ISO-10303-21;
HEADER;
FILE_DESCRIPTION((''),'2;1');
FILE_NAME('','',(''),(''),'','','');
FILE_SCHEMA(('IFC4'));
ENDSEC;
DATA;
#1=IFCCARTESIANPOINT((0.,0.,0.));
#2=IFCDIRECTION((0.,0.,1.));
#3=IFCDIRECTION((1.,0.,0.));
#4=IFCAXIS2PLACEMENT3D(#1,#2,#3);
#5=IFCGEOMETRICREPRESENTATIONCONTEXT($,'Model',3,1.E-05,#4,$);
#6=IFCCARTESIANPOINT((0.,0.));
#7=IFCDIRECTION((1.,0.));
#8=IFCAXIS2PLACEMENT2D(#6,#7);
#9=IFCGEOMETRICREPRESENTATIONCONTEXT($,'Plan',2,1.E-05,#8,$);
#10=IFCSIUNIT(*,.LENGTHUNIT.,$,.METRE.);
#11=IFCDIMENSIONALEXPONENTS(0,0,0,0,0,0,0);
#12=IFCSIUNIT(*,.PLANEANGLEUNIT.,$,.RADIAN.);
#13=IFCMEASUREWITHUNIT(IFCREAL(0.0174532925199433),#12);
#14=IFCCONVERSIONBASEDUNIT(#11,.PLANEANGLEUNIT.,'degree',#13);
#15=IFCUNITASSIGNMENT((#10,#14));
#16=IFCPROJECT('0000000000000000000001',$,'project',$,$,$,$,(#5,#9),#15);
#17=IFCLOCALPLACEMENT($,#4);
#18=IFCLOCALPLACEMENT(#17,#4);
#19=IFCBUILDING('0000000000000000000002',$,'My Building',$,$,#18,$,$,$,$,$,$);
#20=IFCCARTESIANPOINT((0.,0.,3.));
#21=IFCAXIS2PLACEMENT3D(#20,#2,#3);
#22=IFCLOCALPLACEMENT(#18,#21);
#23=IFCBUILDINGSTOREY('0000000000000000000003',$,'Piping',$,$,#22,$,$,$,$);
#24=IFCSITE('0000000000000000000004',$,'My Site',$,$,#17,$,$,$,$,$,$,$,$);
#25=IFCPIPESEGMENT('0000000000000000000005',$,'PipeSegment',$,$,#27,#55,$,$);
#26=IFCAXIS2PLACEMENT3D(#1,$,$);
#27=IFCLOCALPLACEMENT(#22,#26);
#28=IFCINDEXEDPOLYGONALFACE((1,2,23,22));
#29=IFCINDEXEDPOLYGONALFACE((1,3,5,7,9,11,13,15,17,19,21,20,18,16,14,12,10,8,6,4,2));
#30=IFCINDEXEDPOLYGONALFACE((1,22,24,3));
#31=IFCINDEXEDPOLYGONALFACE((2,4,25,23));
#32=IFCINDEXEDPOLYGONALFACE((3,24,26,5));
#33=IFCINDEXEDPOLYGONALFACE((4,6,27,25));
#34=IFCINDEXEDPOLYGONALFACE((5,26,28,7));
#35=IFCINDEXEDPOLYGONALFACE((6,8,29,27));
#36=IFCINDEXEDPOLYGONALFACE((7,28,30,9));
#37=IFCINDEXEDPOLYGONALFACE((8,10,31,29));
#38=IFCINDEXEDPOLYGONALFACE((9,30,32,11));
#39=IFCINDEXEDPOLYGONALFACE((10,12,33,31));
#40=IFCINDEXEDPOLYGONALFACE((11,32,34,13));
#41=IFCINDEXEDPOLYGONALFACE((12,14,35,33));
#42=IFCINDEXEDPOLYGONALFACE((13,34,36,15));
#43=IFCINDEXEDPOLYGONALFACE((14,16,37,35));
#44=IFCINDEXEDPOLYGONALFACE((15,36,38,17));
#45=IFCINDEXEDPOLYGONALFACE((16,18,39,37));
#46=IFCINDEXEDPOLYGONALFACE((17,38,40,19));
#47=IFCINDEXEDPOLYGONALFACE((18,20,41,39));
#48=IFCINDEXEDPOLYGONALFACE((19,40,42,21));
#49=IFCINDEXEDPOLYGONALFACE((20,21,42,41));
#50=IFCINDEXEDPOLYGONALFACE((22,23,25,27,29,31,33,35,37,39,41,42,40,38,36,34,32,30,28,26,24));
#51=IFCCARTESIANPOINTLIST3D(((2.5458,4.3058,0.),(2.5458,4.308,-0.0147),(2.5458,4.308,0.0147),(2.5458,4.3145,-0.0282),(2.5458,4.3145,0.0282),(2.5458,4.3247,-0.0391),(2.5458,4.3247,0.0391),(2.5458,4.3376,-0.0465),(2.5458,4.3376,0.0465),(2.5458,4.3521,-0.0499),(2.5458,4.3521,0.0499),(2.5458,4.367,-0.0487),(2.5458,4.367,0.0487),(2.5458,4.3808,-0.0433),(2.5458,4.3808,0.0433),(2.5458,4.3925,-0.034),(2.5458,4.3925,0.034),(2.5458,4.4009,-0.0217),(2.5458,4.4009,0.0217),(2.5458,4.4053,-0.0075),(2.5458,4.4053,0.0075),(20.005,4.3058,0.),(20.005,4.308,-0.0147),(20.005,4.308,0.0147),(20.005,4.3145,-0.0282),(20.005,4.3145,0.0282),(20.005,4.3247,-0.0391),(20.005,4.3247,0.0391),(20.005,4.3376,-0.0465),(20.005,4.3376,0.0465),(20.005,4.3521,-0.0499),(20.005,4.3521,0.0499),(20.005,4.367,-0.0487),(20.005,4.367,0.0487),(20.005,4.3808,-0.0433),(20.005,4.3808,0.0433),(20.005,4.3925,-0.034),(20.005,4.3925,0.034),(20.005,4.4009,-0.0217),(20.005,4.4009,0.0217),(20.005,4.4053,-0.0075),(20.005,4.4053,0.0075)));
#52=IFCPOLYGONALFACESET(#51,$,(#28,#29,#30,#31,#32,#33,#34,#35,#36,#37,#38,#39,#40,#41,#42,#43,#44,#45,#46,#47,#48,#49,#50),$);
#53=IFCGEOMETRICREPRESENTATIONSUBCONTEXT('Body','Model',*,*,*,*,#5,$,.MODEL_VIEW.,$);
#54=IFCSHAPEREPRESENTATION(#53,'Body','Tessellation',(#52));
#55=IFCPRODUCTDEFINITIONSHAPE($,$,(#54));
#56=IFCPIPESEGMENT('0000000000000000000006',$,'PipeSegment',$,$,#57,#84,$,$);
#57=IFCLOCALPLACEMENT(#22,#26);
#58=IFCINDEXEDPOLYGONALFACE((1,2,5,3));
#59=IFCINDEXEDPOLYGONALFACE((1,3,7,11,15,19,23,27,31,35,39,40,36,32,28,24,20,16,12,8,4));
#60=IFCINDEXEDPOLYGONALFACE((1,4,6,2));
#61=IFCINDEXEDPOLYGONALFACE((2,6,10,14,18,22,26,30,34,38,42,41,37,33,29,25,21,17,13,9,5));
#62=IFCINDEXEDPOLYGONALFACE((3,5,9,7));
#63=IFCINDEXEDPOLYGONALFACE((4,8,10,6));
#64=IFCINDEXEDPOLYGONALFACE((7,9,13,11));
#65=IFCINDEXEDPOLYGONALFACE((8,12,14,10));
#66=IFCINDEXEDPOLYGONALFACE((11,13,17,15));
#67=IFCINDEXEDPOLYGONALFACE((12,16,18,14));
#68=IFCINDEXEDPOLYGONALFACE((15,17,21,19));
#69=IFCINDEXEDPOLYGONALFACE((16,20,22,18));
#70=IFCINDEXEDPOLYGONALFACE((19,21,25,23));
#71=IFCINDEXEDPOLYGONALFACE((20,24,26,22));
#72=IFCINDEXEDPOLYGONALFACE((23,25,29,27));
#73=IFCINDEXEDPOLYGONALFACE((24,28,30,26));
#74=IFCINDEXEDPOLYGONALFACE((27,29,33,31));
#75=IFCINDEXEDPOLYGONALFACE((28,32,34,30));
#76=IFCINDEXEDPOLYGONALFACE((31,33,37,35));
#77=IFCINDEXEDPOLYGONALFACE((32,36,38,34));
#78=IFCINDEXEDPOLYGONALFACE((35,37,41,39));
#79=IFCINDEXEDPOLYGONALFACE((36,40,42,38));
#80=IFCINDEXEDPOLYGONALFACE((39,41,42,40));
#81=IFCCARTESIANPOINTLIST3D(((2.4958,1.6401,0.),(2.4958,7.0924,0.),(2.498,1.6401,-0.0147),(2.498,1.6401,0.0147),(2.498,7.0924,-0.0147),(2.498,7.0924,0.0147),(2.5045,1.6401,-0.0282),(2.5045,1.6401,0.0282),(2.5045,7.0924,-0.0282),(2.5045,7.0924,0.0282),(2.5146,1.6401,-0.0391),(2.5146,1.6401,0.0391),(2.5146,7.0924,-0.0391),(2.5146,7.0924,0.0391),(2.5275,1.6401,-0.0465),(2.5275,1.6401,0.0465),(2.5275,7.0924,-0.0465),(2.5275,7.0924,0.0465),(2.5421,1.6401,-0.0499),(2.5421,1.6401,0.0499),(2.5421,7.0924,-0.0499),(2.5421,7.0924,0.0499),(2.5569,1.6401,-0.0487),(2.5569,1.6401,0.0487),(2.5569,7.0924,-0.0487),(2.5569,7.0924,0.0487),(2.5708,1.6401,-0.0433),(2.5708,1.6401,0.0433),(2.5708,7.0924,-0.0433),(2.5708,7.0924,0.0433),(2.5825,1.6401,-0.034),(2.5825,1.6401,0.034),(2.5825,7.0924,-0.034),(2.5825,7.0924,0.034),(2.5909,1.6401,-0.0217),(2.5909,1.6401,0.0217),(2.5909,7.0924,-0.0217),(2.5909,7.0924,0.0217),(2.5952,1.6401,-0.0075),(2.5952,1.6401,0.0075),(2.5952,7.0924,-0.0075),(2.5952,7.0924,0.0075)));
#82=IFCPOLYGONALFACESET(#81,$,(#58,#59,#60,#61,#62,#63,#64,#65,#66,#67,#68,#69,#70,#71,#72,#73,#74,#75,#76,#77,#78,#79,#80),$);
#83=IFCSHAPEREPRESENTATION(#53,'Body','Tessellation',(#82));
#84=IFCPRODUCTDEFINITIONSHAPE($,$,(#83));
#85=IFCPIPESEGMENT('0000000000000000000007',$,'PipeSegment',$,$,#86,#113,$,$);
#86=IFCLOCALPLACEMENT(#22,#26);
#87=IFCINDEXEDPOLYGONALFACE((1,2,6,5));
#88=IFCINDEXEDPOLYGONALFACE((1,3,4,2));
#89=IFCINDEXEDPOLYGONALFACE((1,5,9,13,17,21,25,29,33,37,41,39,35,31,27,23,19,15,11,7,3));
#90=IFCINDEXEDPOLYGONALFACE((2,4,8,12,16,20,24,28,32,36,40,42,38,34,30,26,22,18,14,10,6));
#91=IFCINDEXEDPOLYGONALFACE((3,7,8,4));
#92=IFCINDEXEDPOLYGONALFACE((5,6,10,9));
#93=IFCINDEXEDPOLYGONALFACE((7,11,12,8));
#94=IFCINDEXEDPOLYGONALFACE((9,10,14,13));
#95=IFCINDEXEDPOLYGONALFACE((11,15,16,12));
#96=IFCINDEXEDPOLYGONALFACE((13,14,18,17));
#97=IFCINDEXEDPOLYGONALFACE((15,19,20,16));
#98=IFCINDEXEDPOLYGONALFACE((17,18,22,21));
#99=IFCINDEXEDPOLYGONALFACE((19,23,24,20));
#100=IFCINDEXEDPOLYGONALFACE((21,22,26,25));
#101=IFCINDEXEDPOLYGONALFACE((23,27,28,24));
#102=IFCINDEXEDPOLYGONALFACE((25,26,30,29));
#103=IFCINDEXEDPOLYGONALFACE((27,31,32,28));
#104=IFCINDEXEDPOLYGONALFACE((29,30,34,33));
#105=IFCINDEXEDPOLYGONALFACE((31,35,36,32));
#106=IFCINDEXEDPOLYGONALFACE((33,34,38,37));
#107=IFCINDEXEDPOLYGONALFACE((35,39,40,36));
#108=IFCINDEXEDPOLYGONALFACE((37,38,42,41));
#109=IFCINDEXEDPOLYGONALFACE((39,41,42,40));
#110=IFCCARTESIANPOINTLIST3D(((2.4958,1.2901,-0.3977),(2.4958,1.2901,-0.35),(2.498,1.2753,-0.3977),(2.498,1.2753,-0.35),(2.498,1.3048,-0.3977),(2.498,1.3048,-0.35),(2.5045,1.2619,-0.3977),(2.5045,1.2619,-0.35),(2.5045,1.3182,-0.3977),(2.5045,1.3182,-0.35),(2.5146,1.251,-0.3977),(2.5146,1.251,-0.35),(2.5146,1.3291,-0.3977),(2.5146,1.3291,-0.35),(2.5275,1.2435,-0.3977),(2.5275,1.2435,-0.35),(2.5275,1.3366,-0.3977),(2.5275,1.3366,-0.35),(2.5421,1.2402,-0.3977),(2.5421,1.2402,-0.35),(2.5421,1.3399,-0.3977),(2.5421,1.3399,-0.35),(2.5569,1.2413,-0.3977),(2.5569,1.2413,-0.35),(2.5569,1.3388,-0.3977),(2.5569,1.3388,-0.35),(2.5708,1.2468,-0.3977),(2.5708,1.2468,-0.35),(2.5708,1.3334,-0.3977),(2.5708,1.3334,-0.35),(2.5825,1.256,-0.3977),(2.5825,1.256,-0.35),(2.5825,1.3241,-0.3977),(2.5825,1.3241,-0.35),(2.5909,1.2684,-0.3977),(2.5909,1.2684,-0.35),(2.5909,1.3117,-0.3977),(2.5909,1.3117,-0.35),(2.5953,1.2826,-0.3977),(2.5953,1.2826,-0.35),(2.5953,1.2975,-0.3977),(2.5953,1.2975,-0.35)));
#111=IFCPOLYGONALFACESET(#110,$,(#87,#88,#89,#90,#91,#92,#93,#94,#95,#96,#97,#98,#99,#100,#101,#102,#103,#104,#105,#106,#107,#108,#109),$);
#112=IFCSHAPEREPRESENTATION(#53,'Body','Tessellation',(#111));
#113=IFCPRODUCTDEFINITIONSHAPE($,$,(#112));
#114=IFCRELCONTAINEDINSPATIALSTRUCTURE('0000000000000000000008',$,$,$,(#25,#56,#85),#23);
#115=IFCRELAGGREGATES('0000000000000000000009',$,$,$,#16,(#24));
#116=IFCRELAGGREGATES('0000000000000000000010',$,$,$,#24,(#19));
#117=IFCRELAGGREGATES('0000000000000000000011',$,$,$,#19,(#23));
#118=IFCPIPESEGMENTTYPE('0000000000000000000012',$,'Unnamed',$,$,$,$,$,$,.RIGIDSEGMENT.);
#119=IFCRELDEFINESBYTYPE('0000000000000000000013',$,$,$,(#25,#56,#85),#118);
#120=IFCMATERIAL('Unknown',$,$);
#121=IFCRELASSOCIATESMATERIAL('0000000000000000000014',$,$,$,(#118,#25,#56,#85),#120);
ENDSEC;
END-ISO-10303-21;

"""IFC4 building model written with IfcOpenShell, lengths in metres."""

from ifc_helpers import new_model, entity, si_unit, converted_unit, frame, origin_with_axes, origin_2d_with_axis, place, context, subcontext, project, spatial, circle, extrude, material, material_profile, profile_set, profile_usage, type_object, element, save


model = new_model("IFC4")

# Units and contexts
model_context = context("Model", 3, precision=1e-05, world=origin_with_axes())
plan_context = context("Plan", 2, precision=1e-05, world=origin_2d_with_axis())
body_context = subcontext(model_context, "Body", "Model", "MODEL_VIEW")
ifc_project = project(units=[si_unit("LENGTHUNIT", "METRE"), converted_unit("PLANEANGLEUNIT", "degree", entity("IfcReal", 0.0174532925199433), si_unit("PLANEANGLEUNIT", "RADIAN"), dimensions=[0, 0, 0, 0, 0, 0, 0])], contexts=[model_context, plan_context])

# Site, building, storey
site_placement = place(None, origin_with_axes())
site = spatial("IfcSite", under=ifc_project, at=site_placement, Name="My Site")
building_placement = place(site_placement, origin_with_axes())
building = spatial("IfcBuilding", under=site, at=building_placement, Name="My Building")
storey_placement = place(building_placement, frame((0.0, 0.0, 3.0), z_axis=(0.0, 0.0, 1.0), x_axis=(1.0, 0.0, 0.0)))
storey = spatial("IfcBuildingStorey", under=building, at=storey_placement, Name="Piping")

# Pipe segments
ifc_material = material(Name="Unknown")
ifc_material_profile = material_profile(ifc_material, circle(Radius=0.05))
ifc_profile_set = profile_set([ifc_material_profile])
ifc_profile_usage_1 = profile_usage(ifc_profile_set, cardinal=5)
pipe_segment_type = type_object("IfcPipeSegmentType", Name="Unnamed", PredefinedType="RIGIDSEGMENT", material=ifc_profile_set)
pipe_segment_1_placement = place(storey_placement, frame((20.005, 4.3558, 0.0), z_axis=(-1.0, 0.0, 0.0), x_axis=(0.0, -1.0, 0.0)))
element("IfcPipeSegment", 1, at=pipe_segment_1_placement, inside=storey, type_object=pipe_segment_type, material=ifc_profile_usage_1, Name="PipeSegment", context=body_context, shape_type="SweptSolid", body=[
    extrude(circle(Radius=0.05), origin_with_axes(), (0.0, 0.0, 1.0), 17.4592),
])
ifc_profile_usage_2 = profile_usage(ifc_profile_set, cardinal=5)
pipe_segment_2_placement = place(storey_placement, frame((2.5458, 7.0924, 0.0), z_axis=(0.0, -1.0, 0.0), x_axis=(-1.0, 0.0, 0.0)))
element("IfcPipeSegment", 2, at=pipe_segment_2_placement, inside=storey, type_object=pipe_segment_type, material=ifc_profile_usage_2, Name="PipeSegment", context=body_context, shape_type="SweptSolid", body=[
    extrude(circle(Radius=0.05), origin_with_axes(), (0.0, 0.0, 1.0), 5.4524),
])
ifc_profile_usage_3 = profile_usage(ifc_profile_set, cardinal=5)
pipe_segment_3_placement = place(storey_placement, frame((2.5458, 1.2901, -0.35), z_axis=(0.0, 0.0, -1.0), x_axis=(-1.0, 0.0, 0.0)))
element("IfcPipeSegment", 3, at=pipe_segment_3_placement, inside=storey, type_object=pipe_segment_type, material=ifc_profile_usage_3, Name="PipeSegment", context=body_context, shape_type="SweptSolid", body=[
    extrude(circle(Radius=0.05), origin_with_axes(), (0.0, 0.0, 1.0), 0.0477),
])

save(model, "model.ifc")
